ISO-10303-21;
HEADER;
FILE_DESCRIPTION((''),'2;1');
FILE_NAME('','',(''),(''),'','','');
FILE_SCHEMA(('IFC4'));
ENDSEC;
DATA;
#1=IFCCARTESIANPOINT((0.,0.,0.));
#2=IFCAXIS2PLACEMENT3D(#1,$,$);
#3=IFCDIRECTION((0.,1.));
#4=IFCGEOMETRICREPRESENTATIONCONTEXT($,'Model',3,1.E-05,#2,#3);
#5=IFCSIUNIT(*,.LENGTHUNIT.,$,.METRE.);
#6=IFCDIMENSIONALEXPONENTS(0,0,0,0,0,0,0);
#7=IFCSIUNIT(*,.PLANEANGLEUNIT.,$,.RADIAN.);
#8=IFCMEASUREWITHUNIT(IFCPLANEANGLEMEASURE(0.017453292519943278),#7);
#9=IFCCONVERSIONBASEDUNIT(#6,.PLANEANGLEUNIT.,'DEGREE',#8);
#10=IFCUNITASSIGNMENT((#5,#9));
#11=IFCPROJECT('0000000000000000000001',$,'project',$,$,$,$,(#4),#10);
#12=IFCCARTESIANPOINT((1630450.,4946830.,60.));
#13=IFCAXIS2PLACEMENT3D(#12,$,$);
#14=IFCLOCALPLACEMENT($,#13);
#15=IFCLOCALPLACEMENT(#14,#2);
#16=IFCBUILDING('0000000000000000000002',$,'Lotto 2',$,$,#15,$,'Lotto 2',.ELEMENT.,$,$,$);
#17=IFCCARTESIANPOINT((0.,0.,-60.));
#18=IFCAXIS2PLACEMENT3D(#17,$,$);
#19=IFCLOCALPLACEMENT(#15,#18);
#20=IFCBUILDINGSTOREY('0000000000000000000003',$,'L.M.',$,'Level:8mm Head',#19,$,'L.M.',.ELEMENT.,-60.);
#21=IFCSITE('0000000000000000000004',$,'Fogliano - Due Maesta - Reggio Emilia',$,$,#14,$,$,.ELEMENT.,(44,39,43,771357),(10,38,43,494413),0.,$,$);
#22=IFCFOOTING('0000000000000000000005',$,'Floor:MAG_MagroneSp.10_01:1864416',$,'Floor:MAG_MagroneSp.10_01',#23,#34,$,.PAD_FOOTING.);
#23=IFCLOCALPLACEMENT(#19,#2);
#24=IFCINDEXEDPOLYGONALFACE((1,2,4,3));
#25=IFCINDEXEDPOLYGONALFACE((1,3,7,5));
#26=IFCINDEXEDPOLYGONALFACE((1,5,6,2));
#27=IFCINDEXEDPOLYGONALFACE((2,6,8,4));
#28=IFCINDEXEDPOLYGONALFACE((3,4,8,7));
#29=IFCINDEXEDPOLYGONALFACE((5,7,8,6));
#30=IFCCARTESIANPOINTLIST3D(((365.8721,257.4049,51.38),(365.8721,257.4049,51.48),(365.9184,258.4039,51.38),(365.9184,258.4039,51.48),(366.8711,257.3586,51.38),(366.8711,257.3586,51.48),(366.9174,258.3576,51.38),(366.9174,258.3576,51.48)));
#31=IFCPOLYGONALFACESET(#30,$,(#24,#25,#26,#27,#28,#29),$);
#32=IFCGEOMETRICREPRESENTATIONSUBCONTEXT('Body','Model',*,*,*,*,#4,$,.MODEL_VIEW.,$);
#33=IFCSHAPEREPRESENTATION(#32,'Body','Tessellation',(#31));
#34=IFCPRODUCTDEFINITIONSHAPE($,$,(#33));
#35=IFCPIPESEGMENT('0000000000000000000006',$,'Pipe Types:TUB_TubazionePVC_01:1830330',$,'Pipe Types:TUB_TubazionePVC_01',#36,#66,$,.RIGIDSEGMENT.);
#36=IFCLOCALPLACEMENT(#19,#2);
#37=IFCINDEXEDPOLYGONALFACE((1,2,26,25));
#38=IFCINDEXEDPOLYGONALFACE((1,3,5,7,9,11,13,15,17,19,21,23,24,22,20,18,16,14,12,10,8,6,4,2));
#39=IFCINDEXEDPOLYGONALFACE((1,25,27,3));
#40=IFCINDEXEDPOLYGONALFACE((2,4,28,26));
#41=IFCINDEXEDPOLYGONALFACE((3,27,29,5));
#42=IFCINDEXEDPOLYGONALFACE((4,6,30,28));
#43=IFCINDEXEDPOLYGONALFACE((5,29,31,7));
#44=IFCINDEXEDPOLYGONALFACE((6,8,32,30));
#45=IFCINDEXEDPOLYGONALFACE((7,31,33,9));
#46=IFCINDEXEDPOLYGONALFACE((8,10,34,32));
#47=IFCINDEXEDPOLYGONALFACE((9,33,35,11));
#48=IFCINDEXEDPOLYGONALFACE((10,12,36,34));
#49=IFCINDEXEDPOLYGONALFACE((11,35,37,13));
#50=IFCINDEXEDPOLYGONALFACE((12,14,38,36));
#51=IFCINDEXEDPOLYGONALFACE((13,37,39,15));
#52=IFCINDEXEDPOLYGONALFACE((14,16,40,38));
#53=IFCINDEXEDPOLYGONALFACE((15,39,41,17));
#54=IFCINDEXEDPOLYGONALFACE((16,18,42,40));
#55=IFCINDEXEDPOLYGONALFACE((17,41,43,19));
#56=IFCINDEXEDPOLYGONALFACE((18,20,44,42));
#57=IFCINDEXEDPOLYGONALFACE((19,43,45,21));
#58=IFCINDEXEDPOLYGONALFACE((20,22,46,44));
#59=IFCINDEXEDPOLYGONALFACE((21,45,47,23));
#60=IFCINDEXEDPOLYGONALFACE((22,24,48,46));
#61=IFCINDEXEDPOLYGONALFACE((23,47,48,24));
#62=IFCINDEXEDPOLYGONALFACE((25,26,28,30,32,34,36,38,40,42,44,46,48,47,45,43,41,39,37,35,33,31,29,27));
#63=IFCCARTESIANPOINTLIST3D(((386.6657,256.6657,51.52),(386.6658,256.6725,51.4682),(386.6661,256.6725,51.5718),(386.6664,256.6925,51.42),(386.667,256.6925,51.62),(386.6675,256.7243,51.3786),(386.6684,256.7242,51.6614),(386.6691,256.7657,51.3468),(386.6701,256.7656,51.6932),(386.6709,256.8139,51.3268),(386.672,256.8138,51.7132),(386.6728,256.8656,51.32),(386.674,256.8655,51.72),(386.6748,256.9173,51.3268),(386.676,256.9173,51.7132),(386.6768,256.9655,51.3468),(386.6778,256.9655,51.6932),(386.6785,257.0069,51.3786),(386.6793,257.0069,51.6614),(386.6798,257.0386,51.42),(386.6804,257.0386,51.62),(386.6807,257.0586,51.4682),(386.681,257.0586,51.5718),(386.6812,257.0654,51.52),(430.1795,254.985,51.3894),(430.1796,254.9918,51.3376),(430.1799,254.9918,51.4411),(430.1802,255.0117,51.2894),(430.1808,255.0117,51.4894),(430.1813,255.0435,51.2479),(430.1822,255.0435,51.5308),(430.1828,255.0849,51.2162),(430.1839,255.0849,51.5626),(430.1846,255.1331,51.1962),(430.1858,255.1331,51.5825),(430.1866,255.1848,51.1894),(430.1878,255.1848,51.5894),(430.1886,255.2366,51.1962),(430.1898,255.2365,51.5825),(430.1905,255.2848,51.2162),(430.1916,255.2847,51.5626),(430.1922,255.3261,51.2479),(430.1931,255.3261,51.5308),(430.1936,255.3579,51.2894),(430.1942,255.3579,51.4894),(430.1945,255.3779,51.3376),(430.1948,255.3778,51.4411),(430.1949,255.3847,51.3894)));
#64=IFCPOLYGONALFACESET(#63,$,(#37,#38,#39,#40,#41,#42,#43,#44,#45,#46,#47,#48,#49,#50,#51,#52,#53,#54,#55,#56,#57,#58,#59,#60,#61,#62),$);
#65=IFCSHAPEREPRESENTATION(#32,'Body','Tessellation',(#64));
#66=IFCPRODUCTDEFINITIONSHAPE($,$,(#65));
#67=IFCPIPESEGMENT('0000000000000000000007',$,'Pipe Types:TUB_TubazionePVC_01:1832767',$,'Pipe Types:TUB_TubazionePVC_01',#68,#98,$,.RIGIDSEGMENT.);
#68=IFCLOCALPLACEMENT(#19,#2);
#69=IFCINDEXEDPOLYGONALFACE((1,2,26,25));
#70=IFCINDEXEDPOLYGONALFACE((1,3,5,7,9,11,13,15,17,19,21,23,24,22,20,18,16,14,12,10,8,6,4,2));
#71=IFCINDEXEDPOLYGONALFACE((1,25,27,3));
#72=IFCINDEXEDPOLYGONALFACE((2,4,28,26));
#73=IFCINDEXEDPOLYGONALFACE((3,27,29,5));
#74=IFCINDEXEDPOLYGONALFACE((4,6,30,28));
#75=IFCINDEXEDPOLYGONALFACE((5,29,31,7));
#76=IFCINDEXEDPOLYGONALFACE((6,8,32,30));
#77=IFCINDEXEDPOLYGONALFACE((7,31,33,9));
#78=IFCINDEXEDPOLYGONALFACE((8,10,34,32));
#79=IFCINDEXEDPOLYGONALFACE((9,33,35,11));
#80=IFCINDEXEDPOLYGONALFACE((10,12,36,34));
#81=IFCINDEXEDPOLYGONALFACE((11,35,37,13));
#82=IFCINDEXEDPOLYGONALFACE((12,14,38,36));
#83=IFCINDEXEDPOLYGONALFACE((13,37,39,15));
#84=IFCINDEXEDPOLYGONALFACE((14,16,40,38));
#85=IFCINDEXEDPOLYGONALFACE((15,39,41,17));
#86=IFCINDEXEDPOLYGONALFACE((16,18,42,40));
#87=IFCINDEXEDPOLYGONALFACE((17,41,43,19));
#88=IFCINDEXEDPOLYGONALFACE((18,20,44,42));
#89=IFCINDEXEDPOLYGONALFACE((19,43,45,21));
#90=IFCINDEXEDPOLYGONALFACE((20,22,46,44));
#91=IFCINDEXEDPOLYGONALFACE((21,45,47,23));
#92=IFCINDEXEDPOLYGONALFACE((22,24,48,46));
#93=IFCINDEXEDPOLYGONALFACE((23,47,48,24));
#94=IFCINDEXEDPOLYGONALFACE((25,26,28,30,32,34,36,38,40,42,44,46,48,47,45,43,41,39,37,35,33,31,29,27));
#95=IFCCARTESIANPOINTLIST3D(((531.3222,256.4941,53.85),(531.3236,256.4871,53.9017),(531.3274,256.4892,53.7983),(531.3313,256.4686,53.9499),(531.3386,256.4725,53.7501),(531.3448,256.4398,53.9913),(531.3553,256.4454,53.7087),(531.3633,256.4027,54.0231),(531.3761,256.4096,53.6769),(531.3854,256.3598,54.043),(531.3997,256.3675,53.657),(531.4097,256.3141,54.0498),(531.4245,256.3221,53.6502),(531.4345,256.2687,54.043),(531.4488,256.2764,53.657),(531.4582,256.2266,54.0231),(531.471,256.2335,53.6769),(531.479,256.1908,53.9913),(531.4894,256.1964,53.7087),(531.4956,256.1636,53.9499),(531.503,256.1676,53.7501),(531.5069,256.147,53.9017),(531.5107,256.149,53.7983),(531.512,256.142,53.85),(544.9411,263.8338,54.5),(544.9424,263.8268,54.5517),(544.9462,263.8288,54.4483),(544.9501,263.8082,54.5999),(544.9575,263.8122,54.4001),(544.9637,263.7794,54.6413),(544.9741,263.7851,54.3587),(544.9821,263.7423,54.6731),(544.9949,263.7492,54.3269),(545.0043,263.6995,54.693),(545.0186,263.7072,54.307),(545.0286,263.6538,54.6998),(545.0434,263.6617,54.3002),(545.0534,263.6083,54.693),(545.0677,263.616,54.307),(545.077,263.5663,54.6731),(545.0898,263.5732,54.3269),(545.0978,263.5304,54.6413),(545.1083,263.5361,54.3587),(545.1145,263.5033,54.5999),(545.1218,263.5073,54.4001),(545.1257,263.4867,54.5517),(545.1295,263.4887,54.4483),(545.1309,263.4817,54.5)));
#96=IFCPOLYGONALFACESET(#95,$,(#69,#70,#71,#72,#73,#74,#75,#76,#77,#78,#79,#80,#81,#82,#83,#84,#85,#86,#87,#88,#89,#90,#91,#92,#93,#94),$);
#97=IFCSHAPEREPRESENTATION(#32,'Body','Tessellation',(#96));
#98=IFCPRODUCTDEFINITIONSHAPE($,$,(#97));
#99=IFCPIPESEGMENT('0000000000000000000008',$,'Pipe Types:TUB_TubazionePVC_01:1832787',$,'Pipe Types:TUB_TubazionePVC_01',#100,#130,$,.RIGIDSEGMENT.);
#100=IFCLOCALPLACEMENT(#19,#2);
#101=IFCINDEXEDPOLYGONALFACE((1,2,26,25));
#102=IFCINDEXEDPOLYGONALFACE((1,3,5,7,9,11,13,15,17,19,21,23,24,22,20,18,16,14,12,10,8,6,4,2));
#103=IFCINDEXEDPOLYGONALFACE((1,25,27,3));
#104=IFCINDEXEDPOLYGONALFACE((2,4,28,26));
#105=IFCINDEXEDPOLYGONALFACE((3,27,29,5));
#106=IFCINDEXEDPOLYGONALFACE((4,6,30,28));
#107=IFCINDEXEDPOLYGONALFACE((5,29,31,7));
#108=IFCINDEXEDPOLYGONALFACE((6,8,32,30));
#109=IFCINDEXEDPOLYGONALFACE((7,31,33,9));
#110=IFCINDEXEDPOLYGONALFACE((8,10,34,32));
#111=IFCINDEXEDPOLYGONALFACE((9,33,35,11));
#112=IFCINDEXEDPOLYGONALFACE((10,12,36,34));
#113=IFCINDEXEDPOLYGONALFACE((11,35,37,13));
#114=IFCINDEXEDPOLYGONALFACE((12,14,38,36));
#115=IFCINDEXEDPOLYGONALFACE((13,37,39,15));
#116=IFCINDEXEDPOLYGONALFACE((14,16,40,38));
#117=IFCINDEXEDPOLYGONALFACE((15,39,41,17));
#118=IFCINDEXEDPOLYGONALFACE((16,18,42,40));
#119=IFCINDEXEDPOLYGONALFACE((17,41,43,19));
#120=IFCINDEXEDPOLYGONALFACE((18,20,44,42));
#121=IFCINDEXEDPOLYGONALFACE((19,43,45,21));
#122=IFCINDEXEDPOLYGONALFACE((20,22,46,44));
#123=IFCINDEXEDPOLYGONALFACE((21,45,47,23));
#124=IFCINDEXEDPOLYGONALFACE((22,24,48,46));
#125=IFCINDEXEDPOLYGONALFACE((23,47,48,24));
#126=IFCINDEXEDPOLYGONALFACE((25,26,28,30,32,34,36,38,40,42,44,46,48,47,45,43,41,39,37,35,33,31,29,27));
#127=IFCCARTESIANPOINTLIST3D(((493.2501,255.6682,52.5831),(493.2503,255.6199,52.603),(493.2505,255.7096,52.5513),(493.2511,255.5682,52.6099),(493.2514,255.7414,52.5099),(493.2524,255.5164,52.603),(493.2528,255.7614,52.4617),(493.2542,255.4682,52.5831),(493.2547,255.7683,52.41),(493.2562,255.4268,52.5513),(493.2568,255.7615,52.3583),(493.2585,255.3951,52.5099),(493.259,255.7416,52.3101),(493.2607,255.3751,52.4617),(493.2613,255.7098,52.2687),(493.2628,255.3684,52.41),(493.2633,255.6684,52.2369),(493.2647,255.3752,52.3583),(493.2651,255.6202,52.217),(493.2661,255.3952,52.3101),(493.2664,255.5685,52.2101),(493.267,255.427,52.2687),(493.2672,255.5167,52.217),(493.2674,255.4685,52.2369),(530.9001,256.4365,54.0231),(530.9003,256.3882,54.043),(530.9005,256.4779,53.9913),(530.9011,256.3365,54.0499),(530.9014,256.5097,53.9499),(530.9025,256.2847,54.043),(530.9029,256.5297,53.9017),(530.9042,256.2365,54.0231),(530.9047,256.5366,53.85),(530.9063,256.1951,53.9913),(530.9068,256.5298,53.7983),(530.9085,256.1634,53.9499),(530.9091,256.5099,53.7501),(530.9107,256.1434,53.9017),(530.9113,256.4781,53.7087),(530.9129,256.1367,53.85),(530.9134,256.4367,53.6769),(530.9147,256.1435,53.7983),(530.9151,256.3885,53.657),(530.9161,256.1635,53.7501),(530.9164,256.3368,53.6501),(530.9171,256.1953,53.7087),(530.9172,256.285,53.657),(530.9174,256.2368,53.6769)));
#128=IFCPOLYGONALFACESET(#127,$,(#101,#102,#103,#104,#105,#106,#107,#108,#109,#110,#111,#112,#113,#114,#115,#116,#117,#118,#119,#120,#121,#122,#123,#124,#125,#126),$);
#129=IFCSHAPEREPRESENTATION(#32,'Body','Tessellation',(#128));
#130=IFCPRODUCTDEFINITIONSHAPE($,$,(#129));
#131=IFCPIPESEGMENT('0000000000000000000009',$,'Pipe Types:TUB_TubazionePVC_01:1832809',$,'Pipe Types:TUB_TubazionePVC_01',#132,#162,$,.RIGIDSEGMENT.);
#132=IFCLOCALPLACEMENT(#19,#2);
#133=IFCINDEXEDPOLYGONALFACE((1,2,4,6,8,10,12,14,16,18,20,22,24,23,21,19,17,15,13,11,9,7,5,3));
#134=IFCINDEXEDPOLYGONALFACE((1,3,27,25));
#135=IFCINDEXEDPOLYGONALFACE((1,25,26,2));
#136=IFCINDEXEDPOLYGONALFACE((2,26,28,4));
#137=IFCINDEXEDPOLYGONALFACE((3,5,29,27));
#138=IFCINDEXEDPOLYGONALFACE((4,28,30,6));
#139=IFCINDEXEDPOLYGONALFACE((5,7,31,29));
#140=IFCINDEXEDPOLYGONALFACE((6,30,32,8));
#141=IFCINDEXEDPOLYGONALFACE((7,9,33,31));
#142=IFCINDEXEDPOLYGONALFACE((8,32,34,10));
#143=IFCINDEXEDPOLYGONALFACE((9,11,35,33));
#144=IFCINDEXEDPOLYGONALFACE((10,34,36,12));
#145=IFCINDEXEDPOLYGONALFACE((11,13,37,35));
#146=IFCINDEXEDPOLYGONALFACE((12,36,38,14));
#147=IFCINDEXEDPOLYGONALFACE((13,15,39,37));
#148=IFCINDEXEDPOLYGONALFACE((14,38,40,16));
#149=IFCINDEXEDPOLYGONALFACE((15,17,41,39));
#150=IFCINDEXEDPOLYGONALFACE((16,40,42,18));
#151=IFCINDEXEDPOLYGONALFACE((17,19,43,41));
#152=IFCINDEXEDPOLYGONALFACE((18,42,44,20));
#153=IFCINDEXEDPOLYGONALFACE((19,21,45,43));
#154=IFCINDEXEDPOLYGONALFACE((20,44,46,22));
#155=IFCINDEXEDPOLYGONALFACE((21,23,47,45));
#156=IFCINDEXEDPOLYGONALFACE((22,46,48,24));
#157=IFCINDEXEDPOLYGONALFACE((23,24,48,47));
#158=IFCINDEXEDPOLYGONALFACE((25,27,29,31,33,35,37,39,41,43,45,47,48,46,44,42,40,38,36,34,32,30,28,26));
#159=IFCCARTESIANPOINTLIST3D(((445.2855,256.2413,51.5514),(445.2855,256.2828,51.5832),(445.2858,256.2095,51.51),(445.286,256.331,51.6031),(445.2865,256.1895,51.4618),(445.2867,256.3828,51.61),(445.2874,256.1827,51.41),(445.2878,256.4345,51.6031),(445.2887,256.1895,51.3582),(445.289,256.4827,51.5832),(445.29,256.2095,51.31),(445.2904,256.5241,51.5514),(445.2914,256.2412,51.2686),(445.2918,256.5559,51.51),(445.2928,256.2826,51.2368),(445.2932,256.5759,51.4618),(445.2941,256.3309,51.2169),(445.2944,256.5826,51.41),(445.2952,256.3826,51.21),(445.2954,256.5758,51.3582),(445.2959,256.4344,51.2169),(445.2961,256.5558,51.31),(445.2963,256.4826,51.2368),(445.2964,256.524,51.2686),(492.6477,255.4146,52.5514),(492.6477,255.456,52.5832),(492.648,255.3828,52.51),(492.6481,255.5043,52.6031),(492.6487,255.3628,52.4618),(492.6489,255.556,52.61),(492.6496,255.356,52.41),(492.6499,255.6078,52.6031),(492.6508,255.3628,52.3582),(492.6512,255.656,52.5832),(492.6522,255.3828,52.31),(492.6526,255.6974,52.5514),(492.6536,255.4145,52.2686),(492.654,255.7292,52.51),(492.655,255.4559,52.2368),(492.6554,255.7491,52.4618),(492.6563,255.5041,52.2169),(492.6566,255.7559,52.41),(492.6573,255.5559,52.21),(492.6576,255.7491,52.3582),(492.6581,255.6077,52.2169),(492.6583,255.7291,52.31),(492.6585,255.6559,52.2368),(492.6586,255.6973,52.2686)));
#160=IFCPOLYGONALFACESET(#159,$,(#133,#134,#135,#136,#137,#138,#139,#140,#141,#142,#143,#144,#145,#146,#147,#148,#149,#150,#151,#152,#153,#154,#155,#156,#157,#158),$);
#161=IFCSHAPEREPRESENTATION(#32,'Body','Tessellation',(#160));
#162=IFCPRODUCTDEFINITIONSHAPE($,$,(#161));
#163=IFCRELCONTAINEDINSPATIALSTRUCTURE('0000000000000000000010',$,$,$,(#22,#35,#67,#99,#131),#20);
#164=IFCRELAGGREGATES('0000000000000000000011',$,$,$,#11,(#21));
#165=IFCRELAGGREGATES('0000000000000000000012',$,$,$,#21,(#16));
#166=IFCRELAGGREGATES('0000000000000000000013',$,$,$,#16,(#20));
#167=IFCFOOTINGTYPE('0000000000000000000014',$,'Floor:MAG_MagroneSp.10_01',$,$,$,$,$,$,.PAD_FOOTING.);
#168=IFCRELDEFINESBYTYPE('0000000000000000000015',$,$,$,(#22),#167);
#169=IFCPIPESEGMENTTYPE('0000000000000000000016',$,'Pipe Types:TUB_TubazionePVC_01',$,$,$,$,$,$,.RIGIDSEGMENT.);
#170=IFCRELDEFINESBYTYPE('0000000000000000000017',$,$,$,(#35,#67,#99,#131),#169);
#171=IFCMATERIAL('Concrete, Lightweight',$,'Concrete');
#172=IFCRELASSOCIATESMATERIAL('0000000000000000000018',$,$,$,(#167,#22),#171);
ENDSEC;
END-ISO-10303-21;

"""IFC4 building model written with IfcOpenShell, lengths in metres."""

from ifc_helpers import new_model, entity, si_unit, converted_unit, direction, frame, origin, place, context, subcontext, project, spatial, arc, indexed_curve, outline, extrude, material, type_object, element, save


model = new_model("IFC4")

# Units and contexts
model_context = context("Model", 3, precision=1e-05, world=origin(), true_north=direction((0.0, 1.0)))
body_context = subcontext(model_context, "Body", "Model", "MODEL_VIEW")
ifc_project = project(units=[si_unit("LENGTHUNIT", "METRE"), converted_unit("PLANEANGLEUNIT", "DEGREE", entity("IfcPlaneAngleMeasure", 0.017453292519943278), si_unit("PLANEANGLEUNIT", "RADIAN"), dimensions=[0, 0, 0, 0, 0, 0, 0])], contexts=[model_context])

# Site, building, storey
site_placement = place(None, frame((1630450.0, 4946830.0, 60.0)))
site = spatial("IfcSite", under=ifc_project, at=site_placement, Name="Fogliano - Due Maesta - Reggio Emilia", CompositionType="ELEMENT", RefLatitude=(44, 39, 43, 771357), RefLongitude=(10, 38, 43, 494413), RefElevation=0.0)
building_placement = place(site_placement, origin())
building = spatial("IfcBuilding", under=site, at=building_placement, Name="Lotto 2", LongName="Lotto 2", CompositionType="ELEMENT")
storey_placement = place(building_placement, frame((0.0, 0.0, -60.0)))
storey = spatial("IfcBuildingStorey", under=building, at=storey_placement, Name="L.M.", ObjectType="Level:8mm Head", LongName="L.M.", CompositionType="ELEMENT", Elevation=-60.0)

# Footing
ifc_material = material(Name="Concrete, Lightweight", Category="Concrete")
footing_type = type_object("IfcFootingType", Name="Floor:MAG_MagroneSp.10_01", PredefinedType="PAD_FOOTING", material=ifc_material)
footing_1_placement = place(storey_placement, origin())
element("IfcFooting", 1, at=footing_1_placement, inside=storey, type_object=footing_type, material=ifc_material, Name="Floor:MAG_MagroneSp.10_01:1864416", ObjectType="Floor:MAG_MagroneSp.10_01", PredefinedType="PAD_FOOTING", context=body_context, shape_type="SweptSolid", body=[
    extrude(outline(indexed_curve([(-0.5, -0.5), (0.5, -0.5), (0.5, 0.5), (-0.5, 0.5), (-0.5, -0.5)], self_intersect=False)), frame((366.3947, 257.8813, 51.48), z_axis=(0.0, 0.0, -1.0), x_axis=(-0.046292, -0.998928, 0.0)), (0.0, 0.0, 1.0), 0.1),
])

# Pipe segments
pipe_segment_type = type_object("IfcPipeSegmentType", Name="Pipe Types:TUB_TubazionePVC_01", PredefinedType="RIGIDSEGMENT")
pipe_segment_1_placement = place(storey_placement, origin())
element("IfcPipeSegment", 2, at=pipe_segment_1_placement, inside=storey, type_object=pipe_segment_type, Name="Pipe Types:TUB_TubazionePVC_01:1830330", ObjectType="Pipe Types:TUB_TubazionePVC_01", PredefinedType="RIGIDSEGMENT", context=body_context, shape_type="SweptSolid", body=[
    extrude(outline(indexed_curve([(0.2, 0.0), (0.1414, 0.1414), (0.0, 0.2), (-0.1414, 0.1414), (-0.2, 0.0), (-0.1414, -0.1414), (0.0, -0.2), (0.1414, -0.1414)], segments=[arc(1, 2, 3), arc(3, 4, 5), arc(5, 6, 7), arc(7, 8, 1)], self_intersect=False)), frame((430.1872, 255.1848, 51.3894), z_axis=(-0.99925, 0.038597, 0.003), x_axis=(-0.038597, -0.999255, 0.0)), (0.0, 0.0, 1.0), 43.5464),
])
pipe_segment_2_placement = place(storey_placement, origin())
element("IfcPipeSegment", 3, at=pipe_segment_2_placement, inside=storey, type_object=pipe_segment_type, Name="Pipe Types:TUB_TubazionePVC_01:1832767", ObjectType="Pipe Types:TUB_TubazionePVC_01", PredefinedType="RIGIDSEGMENT", context=body_context, shape_type="SweptSolid", body=[
    extrude(outline(indexed_curve([(0.2, 0.0), (0.1414, 0.1414), (0.0, 0.2), (-0.1414, 0.1414), (-0.2, 0.0), (-0.1414, -0.1414), (0.0, -0.2), (0.1414, -0.1414)], segments=[arc(1, 2, 3), arc(3, 4, 5), arc(5, 6, 7), arc(7, 8, 1)], self_intersect=False)), frame((531.4171, 256.3181, 53.85), z_axis=(0.879521, 0.474004, 0.041978), x_axis=(-0.474422, 0.880297, 0.0)), (0.0, 0.0, 1.0), 15.4844),
])
pipe_segment_3_placement = place(storey_placement, origin())
element("IfcPipeSegment", 4, at=pipe_segment_3_placement, inside=storey, type_object=pipe_segment_type, Name="Pipe Types:TUB_TubazionePVC_01:1832787", ObjectType="Pipe Types:TUB_TubazionePVC_01", PredefinedType="RIGIDSEGMENT", context=body_context, shape_type="SweptSolid", body=[
    extrude(outline(indexed_curve([(0.2, 0.0), (0.1414, 0.1414), (0.0, 0.2), (-0.1414, 0.1414), (-0.2, 0.0), (-0.1414, -0.1414), (0.0, -0.2), (0.1414, -0.1414)], segments=[arc(1, 2, 3), arc(3, 4, 5), arc(5, 6, 7), arc(7, 8, 1)], self_intersect=False)), frame((493.2588, 255.5683, 52.41), z_axis=(0.999062, 0.020387, 0.038211), x_axis=(-0.020402, 0.999792, 0.0)), (0.0, 0.0, 1.0), 37.6854),
])
pipe_segment_4_placement = place(storey_placement, origin())
element("IfcPipeSegment", 5, at=pipe_segment_4_placement, inside=storey, type_object=pipe_segment_type, Name="Pipe Types:TUB_TubazionePVC_01:1832809", ObjectType="Pipe Types:TUB_TubazionePVC_01", PredefinedType="RIGIDSEGMENT", context=body_context, shape_type="SweptSolid", body=[
    extrude(outline(indexed_curve([(0.2, 0.0), (0.1414, 0.1414), (0.0, 0.2), (-0.1414, 0.1414), (-0.2, 0.0), (-0.1414, -0.1414), (0.0, -0.2), (0.1414, -0.1414)], segments=[arc(1, 2, 3), arc(3, 4, 5), arc(5, 6, 7), arc(7, 8, 1)], self_intersect=False)), frame((492.6531, 255.556, 52.41), z_axis=(-0.999625, 0.017449, -0.021106), x_axis=(0.017452, 0.999848, 0.0)), (0.0, 0.0, 1.0), 47.38),
])

save(model, "model.ifc")
